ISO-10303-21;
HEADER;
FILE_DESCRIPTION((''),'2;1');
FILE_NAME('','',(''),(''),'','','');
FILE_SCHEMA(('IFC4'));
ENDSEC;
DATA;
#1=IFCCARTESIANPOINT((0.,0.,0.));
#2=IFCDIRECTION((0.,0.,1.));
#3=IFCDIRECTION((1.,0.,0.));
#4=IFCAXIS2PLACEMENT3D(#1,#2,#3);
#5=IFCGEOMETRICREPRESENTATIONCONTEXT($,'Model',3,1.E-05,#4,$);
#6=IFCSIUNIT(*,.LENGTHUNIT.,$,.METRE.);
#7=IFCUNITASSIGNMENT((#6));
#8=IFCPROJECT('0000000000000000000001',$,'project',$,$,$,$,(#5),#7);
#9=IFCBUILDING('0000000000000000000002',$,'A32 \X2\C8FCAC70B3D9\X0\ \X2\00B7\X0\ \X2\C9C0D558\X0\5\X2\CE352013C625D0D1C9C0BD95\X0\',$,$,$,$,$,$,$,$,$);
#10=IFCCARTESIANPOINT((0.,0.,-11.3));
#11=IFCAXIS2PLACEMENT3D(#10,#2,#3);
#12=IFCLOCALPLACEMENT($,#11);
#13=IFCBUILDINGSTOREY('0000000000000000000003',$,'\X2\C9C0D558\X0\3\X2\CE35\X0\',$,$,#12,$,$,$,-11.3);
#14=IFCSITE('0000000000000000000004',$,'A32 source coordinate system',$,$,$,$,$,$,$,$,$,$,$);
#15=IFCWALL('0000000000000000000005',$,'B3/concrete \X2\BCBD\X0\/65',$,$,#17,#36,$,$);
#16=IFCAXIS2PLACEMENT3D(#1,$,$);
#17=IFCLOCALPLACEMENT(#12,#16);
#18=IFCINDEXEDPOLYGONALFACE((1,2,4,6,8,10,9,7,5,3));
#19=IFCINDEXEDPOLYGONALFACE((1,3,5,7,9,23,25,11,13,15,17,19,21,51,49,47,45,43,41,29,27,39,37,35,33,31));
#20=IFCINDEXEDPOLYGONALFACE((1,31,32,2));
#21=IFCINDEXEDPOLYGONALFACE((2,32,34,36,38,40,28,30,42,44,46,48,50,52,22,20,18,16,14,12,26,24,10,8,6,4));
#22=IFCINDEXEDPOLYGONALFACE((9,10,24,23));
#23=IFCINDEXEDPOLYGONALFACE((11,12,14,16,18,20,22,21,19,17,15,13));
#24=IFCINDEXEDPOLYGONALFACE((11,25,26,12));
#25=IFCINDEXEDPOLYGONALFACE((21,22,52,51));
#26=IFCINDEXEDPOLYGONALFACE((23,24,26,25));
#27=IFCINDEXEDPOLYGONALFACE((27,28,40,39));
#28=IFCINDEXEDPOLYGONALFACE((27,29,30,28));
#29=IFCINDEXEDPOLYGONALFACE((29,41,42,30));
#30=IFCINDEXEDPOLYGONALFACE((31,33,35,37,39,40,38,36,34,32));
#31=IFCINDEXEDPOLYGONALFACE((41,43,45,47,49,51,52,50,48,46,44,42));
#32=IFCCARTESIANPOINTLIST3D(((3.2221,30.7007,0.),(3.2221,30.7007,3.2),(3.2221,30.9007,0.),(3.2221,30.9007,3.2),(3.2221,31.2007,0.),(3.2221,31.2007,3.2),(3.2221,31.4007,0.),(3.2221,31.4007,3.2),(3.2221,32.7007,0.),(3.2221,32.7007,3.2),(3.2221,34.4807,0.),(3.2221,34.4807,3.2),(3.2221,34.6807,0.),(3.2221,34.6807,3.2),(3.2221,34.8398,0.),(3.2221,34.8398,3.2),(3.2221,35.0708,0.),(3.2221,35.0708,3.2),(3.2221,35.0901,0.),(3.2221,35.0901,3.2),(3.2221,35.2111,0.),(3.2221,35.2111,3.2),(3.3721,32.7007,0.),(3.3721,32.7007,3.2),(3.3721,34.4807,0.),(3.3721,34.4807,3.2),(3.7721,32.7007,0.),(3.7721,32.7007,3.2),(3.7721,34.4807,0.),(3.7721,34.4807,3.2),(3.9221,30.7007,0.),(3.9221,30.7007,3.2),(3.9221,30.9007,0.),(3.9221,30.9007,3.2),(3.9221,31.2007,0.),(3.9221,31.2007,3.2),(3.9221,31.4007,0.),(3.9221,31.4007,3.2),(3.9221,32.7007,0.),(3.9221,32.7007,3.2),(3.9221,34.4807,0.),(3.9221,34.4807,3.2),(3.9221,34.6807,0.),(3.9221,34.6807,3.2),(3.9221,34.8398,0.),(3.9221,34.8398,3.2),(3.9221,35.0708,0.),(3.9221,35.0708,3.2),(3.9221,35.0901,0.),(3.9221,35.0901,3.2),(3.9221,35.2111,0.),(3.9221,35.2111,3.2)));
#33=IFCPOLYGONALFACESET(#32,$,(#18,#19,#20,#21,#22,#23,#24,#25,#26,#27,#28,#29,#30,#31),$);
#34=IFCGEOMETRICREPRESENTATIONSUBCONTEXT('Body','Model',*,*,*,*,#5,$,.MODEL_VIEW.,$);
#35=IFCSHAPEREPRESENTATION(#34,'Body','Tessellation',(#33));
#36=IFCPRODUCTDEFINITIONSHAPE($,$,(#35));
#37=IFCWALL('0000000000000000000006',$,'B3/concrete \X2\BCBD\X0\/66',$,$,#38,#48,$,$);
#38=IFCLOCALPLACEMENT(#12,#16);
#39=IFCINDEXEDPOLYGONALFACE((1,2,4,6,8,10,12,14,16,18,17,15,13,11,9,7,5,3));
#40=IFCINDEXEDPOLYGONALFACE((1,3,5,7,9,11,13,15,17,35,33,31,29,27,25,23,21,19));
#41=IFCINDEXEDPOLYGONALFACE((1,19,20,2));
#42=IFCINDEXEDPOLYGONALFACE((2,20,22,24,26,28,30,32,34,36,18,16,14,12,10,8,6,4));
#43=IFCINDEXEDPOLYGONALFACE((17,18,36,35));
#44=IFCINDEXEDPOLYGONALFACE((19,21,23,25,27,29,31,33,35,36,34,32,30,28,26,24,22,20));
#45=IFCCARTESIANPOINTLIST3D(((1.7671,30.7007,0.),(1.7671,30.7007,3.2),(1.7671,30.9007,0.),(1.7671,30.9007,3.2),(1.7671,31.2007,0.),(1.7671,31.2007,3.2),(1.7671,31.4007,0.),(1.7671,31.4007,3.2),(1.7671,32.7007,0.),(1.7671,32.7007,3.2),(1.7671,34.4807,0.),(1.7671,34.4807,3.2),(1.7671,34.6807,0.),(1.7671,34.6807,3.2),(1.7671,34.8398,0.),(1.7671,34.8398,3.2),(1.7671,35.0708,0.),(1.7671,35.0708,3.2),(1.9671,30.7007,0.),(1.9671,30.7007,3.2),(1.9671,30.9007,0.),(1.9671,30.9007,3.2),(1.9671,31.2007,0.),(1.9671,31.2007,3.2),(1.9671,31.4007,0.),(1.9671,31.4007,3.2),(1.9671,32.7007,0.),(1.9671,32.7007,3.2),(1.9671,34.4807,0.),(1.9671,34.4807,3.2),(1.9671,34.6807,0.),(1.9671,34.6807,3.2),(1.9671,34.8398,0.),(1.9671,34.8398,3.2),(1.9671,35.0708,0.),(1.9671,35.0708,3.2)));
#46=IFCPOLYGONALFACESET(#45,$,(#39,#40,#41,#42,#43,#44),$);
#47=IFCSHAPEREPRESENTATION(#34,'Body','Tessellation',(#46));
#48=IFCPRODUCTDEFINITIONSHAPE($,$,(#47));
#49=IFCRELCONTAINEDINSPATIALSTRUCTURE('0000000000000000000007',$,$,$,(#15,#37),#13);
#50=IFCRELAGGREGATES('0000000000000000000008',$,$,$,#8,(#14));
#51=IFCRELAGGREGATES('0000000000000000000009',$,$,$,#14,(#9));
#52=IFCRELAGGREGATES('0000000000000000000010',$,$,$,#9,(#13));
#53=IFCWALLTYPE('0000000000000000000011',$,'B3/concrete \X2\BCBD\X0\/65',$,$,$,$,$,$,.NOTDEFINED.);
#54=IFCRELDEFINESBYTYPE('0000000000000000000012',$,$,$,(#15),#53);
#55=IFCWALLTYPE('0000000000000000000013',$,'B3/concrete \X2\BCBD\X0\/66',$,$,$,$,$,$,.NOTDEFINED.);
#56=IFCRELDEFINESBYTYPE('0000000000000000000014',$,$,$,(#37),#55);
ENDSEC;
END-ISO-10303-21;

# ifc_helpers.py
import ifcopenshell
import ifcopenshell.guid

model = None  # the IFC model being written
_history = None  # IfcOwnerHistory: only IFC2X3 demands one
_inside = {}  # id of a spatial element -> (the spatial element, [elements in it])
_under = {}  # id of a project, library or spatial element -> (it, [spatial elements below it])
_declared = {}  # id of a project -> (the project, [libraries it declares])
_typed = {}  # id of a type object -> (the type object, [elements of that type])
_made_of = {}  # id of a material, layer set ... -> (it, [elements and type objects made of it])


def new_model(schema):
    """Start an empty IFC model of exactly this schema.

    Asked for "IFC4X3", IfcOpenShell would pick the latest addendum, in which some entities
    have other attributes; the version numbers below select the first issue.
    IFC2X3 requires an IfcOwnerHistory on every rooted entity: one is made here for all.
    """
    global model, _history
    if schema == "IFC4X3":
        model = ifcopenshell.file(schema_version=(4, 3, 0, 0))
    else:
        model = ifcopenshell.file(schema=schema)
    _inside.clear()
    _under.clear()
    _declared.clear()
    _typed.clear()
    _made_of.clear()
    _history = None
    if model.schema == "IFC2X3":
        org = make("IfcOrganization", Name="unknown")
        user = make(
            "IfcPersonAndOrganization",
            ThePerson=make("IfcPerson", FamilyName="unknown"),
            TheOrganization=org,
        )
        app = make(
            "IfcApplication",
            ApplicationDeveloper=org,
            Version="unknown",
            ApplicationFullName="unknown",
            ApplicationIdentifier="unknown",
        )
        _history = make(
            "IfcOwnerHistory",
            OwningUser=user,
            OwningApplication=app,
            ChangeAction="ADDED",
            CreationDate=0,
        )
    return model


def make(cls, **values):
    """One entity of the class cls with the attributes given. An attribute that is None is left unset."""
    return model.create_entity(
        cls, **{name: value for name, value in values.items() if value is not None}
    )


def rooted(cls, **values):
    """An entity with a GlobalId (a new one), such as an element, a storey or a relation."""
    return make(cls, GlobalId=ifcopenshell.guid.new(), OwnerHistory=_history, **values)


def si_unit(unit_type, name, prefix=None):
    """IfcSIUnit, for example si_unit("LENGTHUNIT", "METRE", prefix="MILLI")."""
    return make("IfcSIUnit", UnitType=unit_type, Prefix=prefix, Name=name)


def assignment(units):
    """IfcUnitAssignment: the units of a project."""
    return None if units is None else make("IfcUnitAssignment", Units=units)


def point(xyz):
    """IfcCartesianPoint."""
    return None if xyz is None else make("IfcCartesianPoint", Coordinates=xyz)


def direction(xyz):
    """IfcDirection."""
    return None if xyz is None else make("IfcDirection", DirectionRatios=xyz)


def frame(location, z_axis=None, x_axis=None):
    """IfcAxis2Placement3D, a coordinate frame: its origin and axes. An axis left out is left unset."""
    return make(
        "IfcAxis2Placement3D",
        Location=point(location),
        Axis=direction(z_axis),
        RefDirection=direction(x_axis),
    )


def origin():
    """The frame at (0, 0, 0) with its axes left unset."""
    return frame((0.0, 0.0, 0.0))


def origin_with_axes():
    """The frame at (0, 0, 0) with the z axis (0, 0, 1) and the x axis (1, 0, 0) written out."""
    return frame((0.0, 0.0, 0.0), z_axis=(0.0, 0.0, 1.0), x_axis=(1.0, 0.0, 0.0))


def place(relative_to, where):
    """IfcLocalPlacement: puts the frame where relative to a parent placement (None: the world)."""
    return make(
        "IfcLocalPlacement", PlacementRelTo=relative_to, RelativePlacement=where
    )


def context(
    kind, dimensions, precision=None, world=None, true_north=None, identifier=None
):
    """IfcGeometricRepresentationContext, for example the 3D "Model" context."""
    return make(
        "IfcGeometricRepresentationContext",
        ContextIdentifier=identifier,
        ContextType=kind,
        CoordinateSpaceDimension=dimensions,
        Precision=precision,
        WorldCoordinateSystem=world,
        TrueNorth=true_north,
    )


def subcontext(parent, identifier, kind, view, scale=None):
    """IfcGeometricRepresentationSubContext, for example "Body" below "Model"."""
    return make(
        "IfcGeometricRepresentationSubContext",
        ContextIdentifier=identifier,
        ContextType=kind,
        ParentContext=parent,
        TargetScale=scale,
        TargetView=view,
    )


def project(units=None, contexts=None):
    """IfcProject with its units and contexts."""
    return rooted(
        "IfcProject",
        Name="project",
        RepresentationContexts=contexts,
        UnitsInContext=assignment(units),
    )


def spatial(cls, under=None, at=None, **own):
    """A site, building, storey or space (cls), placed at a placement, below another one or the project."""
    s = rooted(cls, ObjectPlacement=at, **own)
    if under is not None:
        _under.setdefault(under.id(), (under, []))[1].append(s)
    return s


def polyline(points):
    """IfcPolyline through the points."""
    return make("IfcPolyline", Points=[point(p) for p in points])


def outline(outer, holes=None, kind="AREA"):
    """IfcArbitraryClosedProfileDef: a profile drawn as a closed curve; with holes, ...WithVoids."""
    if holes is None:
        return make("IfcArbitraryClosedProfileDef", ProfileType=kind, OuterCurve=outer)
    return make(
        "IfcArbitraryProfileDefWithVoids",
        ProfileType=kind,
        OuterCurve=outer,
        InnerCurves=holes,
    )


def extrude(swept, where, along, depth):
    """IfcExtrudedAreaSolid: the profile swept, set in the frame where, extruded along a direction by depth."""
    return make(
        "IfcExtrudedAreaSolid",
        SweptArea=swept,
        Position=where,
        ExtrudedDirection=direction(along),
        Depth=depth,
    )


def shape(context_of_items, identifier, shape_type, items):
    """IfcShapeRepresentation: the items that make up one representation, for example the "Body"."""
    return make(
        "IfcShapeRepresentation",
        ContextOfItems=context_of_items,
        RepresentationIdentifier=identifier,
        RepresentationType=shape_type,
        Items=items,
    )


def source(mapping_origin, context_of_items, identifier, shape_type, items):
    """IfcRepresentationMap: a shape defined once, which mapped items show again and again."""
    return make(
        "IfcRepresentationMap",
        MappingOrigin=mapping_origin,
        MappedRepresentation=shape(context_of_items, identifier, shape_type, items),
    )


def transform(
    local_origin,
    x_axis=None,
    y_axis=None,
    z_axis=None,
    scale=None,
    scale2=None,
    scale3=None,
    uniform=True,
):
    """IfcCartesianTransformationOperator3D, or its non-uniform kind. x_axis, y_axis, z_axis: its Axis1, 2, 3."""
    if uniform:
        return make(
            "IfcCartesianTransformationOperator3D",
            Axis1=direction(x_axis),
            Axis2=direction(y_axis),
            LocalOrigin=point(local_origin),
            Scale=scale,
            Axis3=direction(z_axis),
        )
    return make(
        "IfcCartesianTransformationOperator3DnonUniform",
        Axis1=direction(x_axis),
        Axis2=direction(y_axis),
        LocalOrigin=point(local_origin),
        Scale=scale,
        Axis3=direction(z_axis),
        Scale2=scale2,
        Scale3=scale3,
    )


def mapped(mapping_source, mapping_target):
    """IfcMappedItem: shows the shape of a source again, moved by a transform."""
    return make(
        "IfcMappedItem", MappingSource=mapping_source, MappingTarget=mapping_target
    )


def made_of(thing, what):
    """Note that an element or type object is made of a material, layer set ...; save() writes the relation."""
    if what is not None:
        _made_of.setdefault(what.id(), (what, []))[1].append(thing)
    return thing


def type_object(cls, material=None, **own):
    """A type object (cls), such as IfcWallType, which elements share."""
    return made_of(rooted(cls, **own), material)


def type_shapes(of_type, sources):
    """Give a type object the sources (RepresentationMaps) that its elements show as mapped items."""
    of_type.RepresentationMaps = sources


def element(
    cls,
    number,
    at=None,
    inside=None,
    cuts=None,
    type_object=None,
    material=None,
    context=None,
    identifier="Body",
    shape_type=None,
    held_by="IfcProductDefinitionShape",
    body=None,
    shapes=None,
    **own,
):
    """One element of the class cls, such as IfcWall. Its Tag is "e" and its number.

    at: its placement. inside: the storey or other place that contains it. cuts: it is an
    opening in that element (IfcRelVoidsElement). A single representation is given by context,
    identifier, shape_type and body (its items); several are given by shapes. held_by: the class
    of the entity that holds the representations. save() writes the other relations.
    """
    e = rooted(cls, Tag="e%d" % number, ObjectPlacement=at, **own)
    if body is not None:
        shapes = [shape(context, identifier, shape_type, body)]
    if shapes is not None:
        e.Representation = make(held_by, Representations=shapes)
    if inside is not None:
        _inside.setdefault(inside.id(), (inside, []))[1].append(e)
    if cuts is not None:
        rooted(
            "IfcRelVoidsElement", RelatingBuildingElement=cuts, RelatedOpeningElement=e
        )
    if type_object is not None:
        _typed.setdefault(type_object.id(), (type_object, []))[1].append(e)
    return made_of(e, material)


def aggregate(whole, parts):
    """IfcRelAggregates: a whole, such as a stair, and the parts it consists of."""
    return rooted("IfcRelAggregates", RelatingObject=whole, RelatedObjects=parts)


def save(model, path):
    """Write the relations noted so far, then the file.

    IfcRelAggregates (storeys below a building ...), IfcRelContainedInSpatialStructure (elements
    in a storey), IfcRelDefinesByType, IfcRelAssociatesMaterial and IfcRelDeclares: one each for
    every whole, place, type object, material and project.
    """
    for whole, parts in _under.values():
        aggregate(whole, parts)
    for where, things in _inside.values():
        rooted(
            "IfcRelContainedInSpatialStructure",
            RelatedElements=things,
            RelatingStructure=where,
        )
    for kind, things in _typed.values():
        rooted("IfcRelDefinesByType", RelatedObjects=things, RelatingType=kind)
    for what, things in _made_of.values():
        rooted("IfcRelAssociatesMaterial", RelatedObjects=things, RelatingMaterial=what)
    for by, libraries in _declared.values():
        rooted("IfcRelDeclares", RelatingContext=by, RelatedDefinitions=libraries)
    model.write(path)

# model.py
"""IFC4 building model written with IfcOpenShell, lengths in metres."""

from ifc_helpers import new_model, si_unit, frame, origin, origin_with_axes, place, context, subcontext, project, spatial, polyline, outline, extrude, source, transform, mapped, type_object, type_shapes, element, save


model = new_model("IFC4")

# Units and contexts
model_context = context("Model", 3, precision=1e-05, world=origin_with_axes())
body_context = subcontext(model_context, "Body", "Model", "MODEL_VIEW")
ifc_project = project(units=[si_unit("LENGTHUNIT", "METRE")], contexts=[model_context])

# Site, building, storey
site = spatial("IfcSite", under=ifc_project, Name="A32 source coordinate system")
building = spatial("IfcBuilding", under=site, Name="A32 주거동 · 지하5층–옥탑지붕")
storey_placement = place(None, frame((0.0, 0.0, -11.3), z_axis=(0.0, 0.0, 1.0), x_axis=(1.0, 0.0, 0.0)))
storey = spatial("IfcBuildingStorey", under=building, at=storey_placement, Name="지하3층", Elevation=-11.3)

# Walls
wall_type_1 = type_object("IfcWallType", Name="B3/concrete 벽/65", PredefinedType="NOTDEFINED")
shared_shape_1 = source(origin(), body_context, "Body", "SweptSolid", [
    extrude(outline(polyline([(3.3721, 32.7007), (3.3721, 34.4807), (3.2221, 34.4807), (3.2221, 34.6807), (3.2221, 34.8398), (3.2221, 35.0708), (3.2221, 35.0901), (3.2221, 35.2111), (3.9221, 35.2111), (3.9221, 35.0901), (3.9221, 35.0708), (3.9221, 34.8398), (3.9221, 34.6807), (3.9221, 34.4807), (3.7721, 34.4807), (3.7721, 32.7007), (3.9221, 32.7007), (3.9221, 31.4007), (3.9221, 31.2007), (3.9221, 30.9007), (3.9221, 30.7007), (3.2221, 30.7007), (3.2221, 30.9007), (3.2221, 31.2007), (3.2221, 31.4007), (3.2221, 32.7007), (3.3721, 32.7007)])), origin(), (0.0, 0.0, 1.0), 3.2),
])
type_shapes(wall_type_1, [shared_shape_1])
wall_1_placement = place(storey_placement, origin_with_axes())
element("IfcWall", 1, at=wall_1_placement, inside=storey, type_object=wall_type_1, Name="B3/concrete 벽/65", context=body_context, shape_type="MappedRepresentation", body=[
    mapped(shared_shape_1, transform((0.0, 0.0, 0.0), scale=1.0)),
])
wall_type_2 = type_object("IfcWallType", Name="B3/concrete 벽/66", PredefinedType="NOTDEFINED")
shared_shape_2 = source(origin(), body_context, "Body", "SweptSolid", [
    extrude(outline(polyline([(1.7671, 34.4807), (1.7671, 34.6807), (1.7671, 34.8398), (1.7671, 35.0708), (1.9671, 35.0708), (1.9671, 34.8398), (1.9671, 34.6807), (1.9671, 34.4807), (1.9671, 32.7007), (1.9671, 31.4007), (1.9671, 31.2007), (1.9671, 30.9007), (1.9671, 30.7007), (1.7671, 30.7007), (1.7671, 30.9007), (1.7671, 31.2007), (1.7671, 31.4007), (1.7671, 32.7007), (1.7671, 34.4807)])), origin(), (0.0, 0.0, 1.0), 3.2),
])
type_shapes(wall_type_2, [shared_shape_2])
wall_2_placement = place(storey_placement, origin_with_axes())
element("IfcWall", 2, at=wall_2_placement, inside=storey, type_object=wall_type_2, Name="B3/concrete 벽/66", context=body_context, shape_type="MappedRepresentation", body=[
    mapped(shared_shape_2, transform((0.0, 0.0, 0.0), scale=1.0)),
])

save(model, "model.ifc")
